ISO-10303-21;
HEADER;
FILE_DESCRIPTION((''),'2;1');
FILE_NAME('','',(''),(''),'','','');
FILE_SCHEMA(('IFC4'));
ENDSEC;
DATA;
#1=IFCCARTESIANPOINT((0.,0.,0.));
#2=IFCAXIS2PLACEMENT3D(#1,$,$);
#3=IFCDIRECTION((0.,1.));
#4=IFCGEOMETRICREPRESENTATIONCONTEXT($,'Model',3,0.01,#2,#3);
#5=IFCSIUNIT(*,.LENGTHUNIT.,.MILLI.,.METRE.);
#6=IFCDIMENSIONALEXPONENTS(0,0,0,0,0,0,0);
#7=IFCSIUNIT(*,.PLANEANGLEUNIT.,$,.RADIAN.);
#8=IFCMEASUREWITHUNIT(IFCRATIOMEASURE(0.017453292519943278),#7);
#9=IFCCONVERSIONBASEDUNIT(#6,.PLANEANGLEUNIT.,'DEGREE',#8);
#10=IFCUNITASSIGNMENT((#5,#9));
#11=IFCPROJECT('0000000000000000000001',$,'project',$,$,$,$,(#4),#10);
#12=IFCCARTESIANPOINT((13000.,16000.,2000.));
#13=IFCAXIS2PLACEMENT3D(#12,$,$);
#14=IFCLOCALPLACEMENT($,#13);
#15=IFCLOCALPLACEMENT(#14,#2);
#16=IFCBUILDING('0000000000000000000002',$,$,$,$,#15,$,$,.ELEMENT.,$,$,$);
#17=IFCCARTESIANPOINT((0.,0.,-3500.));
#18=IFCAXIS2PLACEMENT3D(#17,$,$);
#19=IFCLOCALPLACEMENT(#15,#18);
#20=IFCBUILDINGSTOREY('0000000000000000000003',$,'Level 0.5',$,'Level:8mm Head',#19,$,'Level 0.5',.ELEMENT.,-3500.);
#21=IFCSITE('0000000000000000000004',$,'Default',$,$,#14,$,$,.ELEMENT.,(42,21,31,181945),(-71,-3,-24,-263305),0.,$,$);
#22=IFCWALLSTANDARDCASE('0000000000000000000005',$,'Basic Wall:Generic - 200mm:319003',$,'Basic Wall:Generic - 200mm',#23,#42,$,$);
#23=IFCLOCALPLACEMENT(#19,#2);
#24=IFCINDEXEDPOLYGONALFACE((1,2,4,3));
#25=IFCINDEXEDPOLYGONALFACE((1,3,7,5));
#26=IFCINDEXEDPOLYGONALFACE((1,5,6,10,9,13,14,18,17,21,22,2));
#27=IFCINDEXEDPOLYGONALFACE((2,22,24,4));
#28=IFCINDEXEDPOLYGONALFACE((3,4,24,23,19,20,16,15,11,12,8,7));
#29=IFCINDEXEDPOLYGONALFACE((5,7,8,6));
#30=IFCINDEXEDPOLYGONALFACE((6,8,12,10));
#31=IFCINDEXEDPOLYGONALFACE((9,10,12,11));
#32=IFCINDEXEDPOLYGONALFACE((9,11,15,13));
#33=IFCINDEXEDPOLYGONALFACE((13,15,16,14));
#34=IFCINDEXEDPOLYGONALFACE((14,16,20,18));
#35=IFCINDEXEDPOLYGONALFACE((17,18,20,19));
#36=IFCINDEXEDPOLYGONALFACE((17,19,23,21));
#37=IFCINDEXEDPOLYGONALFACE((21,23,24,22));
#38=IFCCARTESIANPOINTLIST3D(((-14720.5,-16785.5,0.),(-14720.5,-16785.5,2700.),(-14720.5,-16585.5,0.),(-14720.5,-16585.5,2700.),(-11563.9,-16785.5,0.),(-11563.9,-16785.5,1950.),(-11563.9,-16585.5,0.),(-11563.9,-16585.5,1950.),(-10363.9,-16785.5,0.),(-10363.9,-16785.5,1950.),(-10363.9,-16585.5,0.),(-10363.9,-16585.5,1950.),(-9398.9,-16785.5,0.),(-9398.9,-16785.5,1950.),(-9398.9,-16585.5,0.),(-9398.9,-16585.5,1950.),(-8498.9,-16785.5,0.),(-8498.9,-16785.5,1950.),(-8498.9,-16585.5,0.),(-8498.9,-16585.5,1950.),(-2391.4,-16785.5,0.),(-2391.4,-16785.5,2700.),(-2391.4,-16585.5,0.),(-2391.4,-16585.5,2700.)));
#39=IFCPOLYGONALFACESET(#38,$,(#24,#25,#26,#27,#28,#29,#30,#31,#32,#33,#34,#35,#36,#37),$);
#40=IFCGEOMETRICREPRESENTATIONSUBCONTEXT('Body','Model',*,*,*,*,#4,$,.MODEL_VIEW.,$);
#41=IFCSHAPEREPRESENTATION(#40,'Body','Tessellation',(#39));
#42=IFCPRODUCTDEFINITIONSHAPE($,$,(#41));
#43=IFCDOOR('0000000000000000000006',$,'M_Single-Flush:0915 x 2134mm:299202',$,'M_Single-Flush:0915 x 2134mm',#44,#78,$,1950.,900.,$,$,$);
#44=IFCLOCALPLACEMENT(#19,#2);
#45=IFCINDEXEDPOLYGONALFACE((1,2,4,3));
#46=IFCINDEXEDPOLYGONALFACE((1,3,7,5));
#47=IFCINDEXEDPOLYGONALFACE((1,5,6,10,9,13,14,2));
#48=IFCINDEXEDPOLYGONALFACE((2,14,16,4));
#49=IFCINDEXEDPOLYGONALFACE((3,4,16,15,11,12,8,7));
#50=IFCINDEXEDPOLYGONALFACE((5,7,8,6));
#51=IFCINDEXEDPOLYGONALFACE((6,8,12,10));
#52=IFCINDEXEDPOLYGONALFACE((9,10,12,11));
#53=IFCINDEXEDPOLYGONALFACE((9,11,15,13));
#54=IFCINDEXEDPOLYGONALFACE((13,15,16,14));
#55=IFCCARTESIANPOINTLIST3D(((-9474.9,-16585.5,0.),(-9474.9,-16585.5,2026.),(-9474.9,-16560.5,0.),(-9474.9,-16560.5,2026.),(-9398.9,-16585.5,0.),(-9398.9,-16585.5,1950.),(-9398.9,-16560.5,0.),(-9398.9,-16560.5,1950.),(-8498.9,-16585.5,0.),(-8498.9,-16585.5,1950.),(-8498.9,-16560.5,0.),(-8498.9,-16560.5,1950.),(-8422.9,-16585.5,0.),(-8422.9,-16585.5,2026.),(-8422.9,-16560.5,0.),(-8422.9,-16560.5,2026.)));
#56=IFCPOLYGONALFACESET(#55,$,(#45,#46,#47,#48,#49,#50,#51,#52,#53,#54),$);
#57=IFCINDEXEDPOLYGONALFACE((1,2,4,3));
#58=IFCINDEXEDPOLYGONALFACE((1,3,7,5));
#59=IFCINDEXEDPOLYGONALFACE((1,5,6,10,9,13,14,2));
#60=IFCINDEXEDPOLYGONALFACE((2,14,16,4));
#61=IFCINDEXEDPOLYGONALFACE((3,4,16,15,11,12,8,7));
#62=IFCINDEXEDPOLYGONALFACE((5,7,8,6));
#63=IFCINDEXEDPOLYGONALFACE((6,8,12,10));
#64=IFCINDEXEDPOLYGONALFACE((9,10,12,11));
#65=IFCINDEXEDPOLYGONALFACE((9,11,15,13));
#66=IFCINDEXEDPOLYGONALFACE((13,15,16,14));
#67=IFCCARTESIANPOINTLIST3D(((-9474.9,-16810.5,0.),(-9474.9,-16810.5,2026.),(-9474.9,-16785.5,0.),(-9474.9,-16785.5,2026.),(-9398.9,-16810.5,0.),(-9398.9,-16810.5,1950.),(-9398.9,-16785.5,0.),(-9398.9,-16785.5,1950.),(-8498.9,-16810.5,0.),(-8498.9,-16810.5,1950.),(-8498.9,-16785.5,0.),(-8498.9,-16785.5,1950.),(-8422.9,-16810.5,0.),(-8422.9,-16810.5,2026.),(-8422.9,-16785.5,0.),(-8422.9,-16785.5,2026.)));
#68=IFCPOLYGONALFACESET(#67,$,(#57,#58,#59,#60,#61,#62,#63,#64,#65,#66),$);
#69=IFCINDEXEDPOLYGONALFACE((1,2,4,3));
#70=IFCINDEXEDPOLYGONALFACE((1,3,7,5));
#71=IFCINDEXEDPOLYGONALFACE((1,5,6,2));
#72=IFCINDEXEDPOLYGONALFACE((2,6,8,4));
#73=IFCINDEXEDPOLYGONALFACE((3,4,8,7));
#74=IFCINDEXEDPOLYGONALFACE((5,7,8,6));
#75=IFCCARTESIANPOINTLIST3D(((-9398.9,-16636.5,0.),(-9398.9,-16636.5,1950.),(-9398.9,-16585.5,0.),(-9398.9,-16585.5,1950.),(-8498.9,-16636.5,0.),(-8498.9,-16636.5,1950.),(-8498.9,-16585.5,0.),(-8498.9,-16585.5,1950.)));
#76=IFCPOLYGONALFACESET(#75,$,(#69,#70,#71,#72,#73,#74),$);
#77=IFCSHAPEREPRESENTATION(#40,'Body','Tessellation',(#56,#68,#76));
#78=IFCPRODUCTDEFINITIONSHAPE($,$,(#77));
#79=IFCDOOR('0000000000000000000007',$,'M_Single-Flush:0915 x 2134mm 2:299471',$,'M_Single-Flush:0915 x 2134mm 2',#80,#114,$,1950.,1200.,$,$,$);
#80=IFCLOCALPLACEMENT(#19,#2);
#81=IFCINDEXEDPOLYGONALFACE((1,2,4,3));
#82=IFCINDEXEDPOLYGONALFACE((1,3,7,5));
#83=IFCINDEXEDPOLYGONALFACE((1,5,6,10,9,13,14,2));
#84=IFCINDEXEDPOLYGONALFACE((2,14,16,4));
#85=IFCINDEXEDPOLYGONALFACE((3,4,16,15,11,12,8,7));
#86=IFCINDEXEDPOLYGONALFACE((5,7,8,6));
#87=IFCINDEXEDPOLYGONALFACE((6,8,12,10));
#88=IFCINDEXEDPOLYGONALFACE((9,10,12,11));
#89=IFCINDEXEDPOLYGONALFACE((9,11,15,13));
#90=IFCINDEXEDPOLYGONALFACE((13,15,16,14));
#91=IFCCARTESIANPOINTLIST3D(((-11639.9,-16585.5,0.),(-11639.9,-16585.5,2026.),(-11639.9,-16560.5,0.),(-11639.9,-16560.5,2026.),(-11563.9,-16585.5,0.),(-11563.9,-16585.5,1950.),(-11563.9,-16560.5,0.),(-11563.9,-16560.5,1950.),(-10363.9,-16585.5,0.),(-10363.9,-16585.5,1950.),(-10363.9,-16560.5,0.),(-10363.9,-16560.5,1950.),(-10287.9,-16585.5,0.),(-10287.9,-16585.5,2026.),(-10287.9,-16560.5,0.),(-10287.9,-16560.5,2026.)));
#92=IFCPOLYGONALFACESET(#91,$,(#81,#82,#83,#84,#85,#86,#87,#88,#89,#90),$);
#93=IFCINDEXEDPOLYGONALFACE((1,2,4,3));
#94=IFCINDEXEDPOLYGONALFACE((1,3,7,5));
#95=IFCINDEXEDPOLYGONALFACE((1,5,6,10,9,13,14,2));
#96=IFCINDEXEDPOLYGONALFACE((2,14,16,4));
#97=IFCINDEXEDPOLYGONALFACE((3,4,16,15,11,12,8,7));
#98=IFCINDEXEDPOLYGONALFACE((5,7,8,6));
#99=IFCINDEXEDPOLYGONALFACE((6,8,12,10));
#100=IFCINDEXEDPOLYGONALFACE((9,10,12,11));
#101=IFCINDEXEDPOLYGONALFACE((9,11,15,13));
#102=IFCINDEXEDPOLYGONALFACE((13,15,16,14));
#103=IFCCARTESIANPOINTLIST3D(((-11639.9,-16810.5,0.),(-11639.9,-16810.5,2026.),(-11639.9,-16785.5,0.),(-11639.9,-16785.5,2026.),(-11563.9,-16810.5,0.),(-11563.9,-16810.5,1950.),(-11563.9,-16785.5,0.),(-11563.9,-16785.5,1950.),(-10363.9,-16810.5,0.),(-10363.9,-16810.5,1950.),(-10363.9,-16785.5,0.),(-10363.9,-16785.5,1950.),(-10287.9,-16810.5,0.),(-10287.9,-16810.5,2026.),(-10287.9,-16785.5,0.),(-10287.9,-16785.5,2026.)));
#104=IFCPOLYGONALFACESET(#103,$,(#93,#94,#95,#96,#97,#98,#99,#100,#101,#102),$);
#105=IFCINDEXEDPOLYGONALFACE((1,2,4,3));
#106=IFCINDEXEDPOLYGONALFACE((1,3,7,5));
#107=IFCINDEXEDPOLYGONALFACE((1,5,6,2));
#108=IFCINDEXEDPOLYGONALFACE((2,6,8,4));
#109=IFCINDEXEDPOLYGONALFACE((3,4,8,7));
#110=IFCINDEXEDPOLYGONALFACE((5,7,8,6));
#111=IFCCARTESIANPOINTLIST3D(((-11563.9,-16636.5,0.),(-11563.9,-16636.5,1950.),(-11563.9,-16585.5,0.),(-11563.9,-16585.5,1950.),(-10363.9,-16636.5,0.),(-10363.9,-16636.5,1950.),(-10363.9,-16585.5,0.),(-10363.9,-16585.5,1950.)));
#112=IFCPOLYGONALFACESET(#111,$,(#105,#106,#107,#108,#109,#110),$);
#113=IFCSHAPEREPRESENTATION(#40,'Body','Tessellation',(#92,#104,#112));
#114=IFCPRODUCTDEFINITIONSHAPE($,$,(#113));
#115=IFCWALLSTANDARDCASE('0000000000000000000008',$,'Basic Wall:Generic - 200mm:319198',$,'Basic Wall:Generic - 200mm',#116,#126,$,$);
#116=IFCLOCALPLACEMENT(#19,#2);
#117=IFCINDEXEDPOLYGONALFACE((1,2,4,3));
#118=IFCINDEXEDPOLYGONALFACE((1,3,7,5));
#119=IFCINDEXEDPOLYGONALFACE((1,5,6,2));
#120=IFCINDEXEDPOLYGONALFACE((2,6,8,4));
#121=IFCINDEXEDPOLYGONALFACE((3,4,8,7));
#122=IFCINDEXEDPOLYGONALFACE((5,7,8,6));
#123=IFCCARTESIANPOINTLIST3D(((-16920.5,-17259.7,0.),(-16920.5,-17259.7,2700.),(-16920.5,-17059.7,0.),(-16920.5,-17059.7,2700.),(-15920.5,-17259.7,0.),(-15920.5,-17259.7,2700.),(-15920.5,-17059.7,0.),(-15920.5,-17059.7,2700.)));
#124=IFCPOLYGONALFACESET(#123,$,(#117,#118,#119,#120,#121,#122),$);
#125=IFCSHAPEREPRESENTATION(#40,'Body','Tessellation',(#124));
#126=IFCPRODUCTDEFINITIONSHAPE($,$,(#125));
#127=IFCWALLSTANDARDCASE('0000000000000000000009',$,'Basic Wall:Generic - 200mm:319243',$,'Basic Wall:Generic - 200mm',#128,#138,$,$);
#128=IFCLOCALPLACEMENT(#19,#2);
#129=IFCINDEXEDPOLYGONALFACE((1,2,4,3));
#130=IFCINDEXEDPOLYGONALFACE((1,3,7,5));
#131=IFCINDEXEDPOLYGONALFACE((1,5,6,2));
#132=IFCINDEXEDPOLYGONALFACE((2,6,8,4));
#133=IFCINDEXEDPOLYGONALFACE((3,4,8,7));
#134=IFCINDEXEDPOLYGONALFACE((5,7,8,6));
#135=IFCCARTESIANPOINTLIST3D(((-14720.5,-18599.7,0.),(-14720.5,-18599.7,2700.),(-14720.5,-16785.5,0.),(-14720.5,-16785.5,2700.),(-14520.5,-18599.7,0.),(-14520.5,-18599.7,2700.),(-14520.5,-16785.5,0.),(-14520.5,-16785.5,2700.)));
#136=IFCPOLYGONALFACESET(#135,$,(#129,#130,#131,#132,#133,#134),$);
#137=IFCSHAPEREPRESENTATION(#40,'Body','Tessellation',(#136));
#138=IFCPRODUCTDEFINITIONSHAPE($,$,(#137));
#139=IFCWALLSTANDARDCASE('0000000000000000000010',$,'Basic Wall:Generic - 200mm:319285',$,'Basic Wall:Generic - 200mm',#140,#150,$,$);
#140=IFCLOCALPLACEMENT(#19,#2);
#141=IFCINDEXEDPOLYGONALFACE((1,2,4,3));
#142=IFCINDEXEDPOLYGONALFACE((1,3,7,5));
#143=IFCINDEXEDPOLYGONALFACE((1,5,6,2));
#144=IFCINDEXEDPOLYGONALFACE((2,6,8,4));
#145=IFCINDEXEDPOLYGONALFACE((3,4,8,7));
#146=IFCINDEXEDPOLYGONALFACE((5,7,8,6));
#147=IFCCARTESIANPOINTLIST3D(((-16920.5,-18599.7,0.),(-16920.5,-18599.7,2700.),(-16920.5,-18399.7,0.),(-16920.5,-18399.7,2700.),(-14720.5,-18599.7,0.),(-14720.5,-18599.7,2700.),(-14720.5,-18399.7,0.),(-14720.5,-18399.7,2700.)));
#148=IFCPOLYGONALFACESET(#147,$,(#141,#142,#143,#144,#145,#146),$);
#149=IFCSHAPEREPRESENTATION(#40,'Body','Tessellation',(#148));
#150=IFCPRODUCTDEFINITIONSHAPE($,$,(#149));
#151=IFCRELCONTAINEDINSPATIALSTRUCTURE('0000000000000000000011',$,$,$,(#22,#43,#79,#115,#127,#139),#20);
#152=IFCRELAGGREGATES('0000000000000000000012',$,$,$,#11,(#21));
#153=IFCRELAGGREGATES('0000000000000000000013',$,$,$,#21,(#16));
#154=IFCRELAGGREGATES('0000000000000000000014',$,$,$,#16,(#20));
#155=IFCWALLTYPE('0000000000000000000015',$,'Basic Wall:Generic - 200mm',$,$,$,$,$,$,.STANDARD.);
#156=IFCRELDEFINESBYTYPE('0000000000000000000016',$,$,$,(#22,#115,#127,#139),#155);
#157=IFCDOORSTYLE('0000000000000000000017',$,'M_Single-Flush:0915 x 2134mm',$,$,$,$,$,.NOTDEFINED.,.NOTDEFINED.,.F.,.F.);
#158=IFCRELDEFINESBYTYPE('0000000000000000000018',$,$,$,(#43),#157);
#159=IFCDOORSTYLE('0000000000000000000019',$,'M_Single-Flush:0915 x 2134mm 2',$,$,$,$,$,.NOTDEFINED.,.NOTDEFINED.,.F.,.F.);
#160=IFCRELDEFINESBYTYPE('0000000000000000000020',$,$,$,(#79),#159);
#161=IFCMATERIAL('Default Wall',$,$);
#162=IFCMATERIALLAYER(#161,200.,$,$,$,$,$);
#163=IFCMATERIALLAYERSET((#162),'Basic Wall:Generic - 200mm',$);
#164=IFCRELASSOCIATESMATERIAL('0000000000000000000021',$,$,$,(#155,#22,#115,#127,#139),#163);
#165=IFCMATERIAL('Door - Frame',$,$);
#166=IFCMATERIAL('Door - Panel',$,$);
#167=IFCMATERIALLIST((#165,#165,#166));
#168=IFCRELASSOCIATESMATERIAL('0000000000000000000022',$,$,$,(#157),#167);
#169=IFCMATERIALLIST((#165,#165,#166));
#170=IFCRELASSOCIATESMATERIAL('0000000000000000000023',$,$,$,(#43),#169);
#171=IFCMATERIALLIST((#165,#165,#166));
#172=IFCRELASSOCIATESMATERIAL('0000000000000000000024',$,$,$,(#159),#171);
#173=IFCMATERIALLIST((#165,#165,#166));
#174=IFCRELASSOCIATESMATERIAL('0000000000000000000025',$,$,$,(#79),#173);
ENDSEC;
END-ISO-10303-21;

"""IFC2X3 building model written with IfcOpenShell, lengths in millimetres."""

from ifc_helpers import new_model, entity, si_unit, converted_unit, direction, frame, frame_2d, origin, place, context, subcontext, project, spatial, polyline, rectangle, outline, extrude, source, transform, mapped, material, material_list, layer, layer_set, layer_usage, type_object, type_shapes, element, fill, save


model = new_model("IFC2X3")

# Units and contexts
model_context = context("Model", 3, precision=0.01, world=origin(), true_north=direction((0.0, 1.0)))
body_context = subcontext(model_context, "Body", "Model", "MODEL_VIEW")
ifc_project = project(units=[si_unit("LENGTHUNIT", "METRE", prefix="MILLI"), converted_unit("PLANEANGLEUNIT", "DEGREE", entity("IfcRatioMeasure", 0.017453292519943278), si_unit("PLANEANGLEUNIT", "RADIAN"), dimensions=[0, 0, 0, 0, 0, 0, 0])], contexts=[model_context])

# Site, building, storey
site_placement = place(None, frame((13000.0, 16000.0, 2000.0)))
site = spatial("IfcSite", under=ifc_project, at=site_placement, Name="Default", CompositionType="ELEMENT", RefLatitude=(42, 21, 31, 181945), RefLongitude=(-71, -3, -24, -263305), RefElevation=0.0)
building_placement = place(site_placement, origin())
building = spatial("IfcBuilding", under=site, at=building_placement, CompositionType="ELEMENT")
storey_placement = place(building_placement, frame((0.0, 0.0, -3500.0)))
storey = spatial("IfcBuildingStorey", under=building, at=storey_placement, Name="Level 0.5", ObjectType="Level:8mm Head", LongName="Level 0.5", CompositionType="ELEMENT", Elevation=-3500.0)

# Shared definitions
ifc_material_1 = material(Name="Default Wall")
ifc_layer_1 = layer(ifc_material_1, 200.0)
ifc_layer_set_1 = layer_set([ifc_layer_1], Name="Basic Wall:Generic - 200mm")
wall_type_1 = type_object("IfcWallType", Name="Basic Wall:Generic - 200mm", PredefinedType="STANDARD", material=ifc_layer_set_1)

# Shared definitions
ifc_material_2 = material(Name="Door - Frame")
ifc_material_3 = material(Name="Door - Panel")
ifc_material_list_1 = material_list([ifc_material_2, ifc_material_2, ifc_material_3])
door_style_1 = type_object("IfcDoorStyle", Name="M_Single-Flush:0915 x 2134mm", ConstructionType="NOTDEFINED", OperationType="NOTDEFINED", ParameterTakesPrecedence=False, Sizeable=False, material=ifc_material_list_1)
shared_shape_1 = source(origin(), body_context, "Body", "SweptSolid", [
    extrude(outline(polyline([(-526.0, -1032.0), (526.0, -1032.0), (526.0, 994.0), (450.0, 994.0), (450.0, -956.0), (-450.0, -956.0), (-450.0, 994.0), (-526.0, 994.0), (-526.0, -1032.0)])), frame((450.0, 225.0, 994.0), z_axis=(0.0, -1.0, 0.0), x_axis=(-1.0, 0.0, 0.0)), (0.0, 0.0, 1.0), 25.0),
    extrude(outline(polyline([(-1032.0, -526.0), (994.0, -526.0), (994.0, -450.0), (-956.0, -450.0), (-956.0, 450.0), (994.0, 450.0), (994.0, 526.0), (-1032.0, 526.0), (-1032.0, -526.0)])), frame((450.0, 0.0, 994.0), z_axis=(0.0, -1.0, 0.0), x_axis=(0.0, 0.0, -1.0)), (0.0, 0.0, 1.0), 25.0),
    extrude(rectangle(XDim=900.0, YDim=51.0, at=frame_2d((0.0, 0.0), x_axis=(1.0, 0.0))), frame((450.0, 174.5, 0.0)), (0.0, 0.0, 1.0), 1950.0),
])
type_shapes(door_style_1, [shared_shape_1])

# Wall, openings, doors
ifc_layer_usage_1 = layer_usage(ifc_layer_set_1, "AXIS2", "NEGATIVE", 100.0)
wall_1_placement = place(storey_placement, frame((-14720.5, -16685.5, 0.0)))
wall_1 = element("IfcWallStandardCase", 1, at=wall_1_placement, inside=storey, type_object=wall_type_1, material=ifc_layer_usage_1, Name="Basic Wall:Generic - 200mm:319003", ObjectType="Basic Wall:Generic - 200mm", context=body_context, shape_type="SweptSolid", body=[
    extrude(rectangle(XDim=12329.1, YDim=200.0, at=frame_2d((6164.6, 0.0), x_axis=(1.0, 0.0))), origin(), (0.0, 0.0, 1.0), 2700.0),
])
opening_1_placement = place(wall_1_placement, frame((5321.6, -100.0, 0.0)))
opening_1 = element("IfcOpeningElement", 2, at=opening_1_placement, cuts=wall_1, ObjectType="Opening", context=body_context, shape_type="SweptSolid", body=[
    extrude(rectangle(XDim=900.0, YDim=1950.0, at=frame_2d((975.0, 450.0), x_axis=(0.0, -1.0))), frame((0.0, 0.0, 0.0), z_axis=(0.0, 1.0, 0.0), x_axis=(0.0, 0.0, 1.0)), (0.0, 0.0, 1.0), 200.0),
])
opening_2_placement = place(wall_1_placement, frame((3156.6, -100.0, 0.0)))
opening_2 = element("IfcOpeningElement", 3, at=opening_2_placement, cuts=wall_1, ObjectType="Opening", context=body_context, shape_type="SweptSolid", body=[
    extrude(rectangle(XDim=1200.0, YDim=1950.0, at=frame_2d((975.0, 600.0), x_axis=(0.0, -1.0))), frame((0.0, 0.0, 0.0), z_axis=(0.0, 1.0, 0.0), x_axis=(0.0, 0.0, 1.0)), (0.0, 0.0, 1.0), 200.0),
])
ifc_material_list_2 = material_list([ifc_material_2, ifc_material_2, ifc_material_3])
door_1_placement = place(opening_1_placement, origin())
door_1 = element("IfcDoor", 4, at=door_1_placement, inside=storey, type_object=door_style_1, material=ifc_material_list_2, Name="M_Single-Flush:0915 x 2134mm:299202", ObjectType="M_Single-Flush:0915 x 2134mm", OverallHeight=1950.0, OverallWidth=900.0, context=body_context, shape_type="MappedRepresentation", body=[
    mapped(shared_shape_1, transform((0.0, 0.0, 0.0), scale=1.0)),
])
fill(opening_1, door_1)
ifc_material_list_3 = material_list([ifc_material_2, ifc_material_2, ifc_material_3])
ifc_material_list_4 = material_list([ifc_material_2, ifc_material_2, ifc_material_3])
door_style_2 = type_object("IfcDoorStyle", Name="M_Single-Flush:0915 x 2134mm 2", ConstructionType="NOTDEFINED", OperationType="NOTDEFINED", ParameterTakesPrecedence=False, Sizeable=False, material=ifc_material_list_4)
shared_shape_2 = source(origin(), body_context, "Body", "SweptSolid", [
    extrude(outline(polyline([(-676.0, -1032.0), (676.0, -1032.0), (676.0, 994.0), (600.0, 994.0), (600.0, -956.0), (-600.0, -956.0), (-600.0, 994.0), (-676.0, 994.0), (-676.0, -1032.0)])), frame((600.0, 225.0, 994.0), z_axis=(0.0, -1.0, 0.0), x_axis=(-1.0, 0.0, 0.0)), (0.0, 0.0, 1.0), 25.0),
    extrude(outline(polyline([(-1032.0, -676.0), (994.0, -676.0), (994.0, -600.0), (-956.0, -600.0), (-956.0, 600.0), (994.0, 600.0), (994.0, 676.0), (-1032.0, 676.0), (-1032.0, -676.0)])), frame((600.0, 0.0, 994.0), z_axis=(0.0, -1.0, 0.0), x_axis=(0.0, 0.0, -1.0)), (0.0, 0.0, 1.0), 25.0),
    extrude(rectangle(XDim=1200.0, YDim=51.0, at=frame_2d((0.0, 0.0), x_axis=(1.0, 0.0))), frame((600.0, 174.5, 0.0)), (0.0, 0.0, 1.0), 1950.0),
])
type_shapes(door_style_2, [shared_shape_2])
door_2_placement = place(opening_2_placement, origin())
door_2 = element("IfcDoor", 5, at=door_2_placement, inside=storey, type_object=door_style_2, material=ifc_material_list_3, Name="M_Single-Flush:0915 x 2134mm 2:299471", ObjectType="M_Single-Flush:0915 x 2134mm 2", OverallHeight=1950.0, OverallWidth=1200.0, context=body_context, shape_type="MappedRepresentation", body=[
    mapped(shared_shape_2, transform((0.0, 0.0, 0.0), scale=1.0)),
])
fill(opening_2, door_2)

# Walls
ifc_layer_usage_2 = layer_usage(ifc_layer_set_1, "AXIS2", "NEGATIVE", 100.0)
wall_2_placement = place(storey_placement, frame((-15920.5, -17159.7, 0.0), z_axis=(0.0, 0.0, 1.0), x_axis=(-1.0, 0.0, 0.0)))
element("IfcWallStandardCase", 6, at=wall_2_placement, inside=storey, type_object=wall_type_1, material=ifc_layer_usage_2, Name="Basic Wall:Generic - 200mm:319198", ObjectType="Basic Wall:Generic - 200mm", context=body_context, shape_type="SweptSolid", body=[
    extrude(rectangle(XDim=1000.0, YDim=200.0, at=frame_2d((500.0, 0.0), x_axis=(-1.0, 0.0))), origin(), (0.0, 0.0, 1.0), 2700.0),
])
ifc_layer_usage_3 = layer_usage(ifc_layer_set_1, "AXIS2", "NEGATIVE", 100.0)
wall_3_placement = place(storey_placement, frame((-14620.5, -16785.5, 0.0), z_axis=(0.0, 0.0, 1.0), x_axis=(0.0, -1.0, 0.0)))
element("IfcWallStandardCase", 7, at=wall_3_placement, inside=storey, type_object=wall_type_1, material=ifc_layer_usage_3, Name="Basic Wall:Generic - 200mm:319243", ObjectType="Basic Wall:Generic - 200mm", context=body_context, shape_type="SweptSolid", body=[
    extrude(rectangle(XDim=1814.2, YDim=200.0, at=frame_2d((907.1, 0.0), x_axis=(-1.0, 0.0))), origin(), (0.0, 0.0, 1.0), 2700.0),
])
ifc_layer_usage_4 = layer_usage(ifc_layer_set_1, "AXIS2", "NEGATIVE", 100.0)
wall_4_placement = place(storey_placement, frame((-14720.5, -18499.7, 0.0), z_axis=(0.0, 0.0, 1.0), x_axis=(-1.0, 0.0, 0.0)))
element("IfcWallStandardCase", 8, at=wall_4_placement, inside=storey, type_object=wall_type_1, material=ifc_layer_usage_4, Name="Basic Wall:Generic - 200mm:319285", ObjectType="Basic Wall:Generic - 200mm", context=body_context, shape_type="SweptSolid", body=[
    extrude(rectangle(XDim=2200.0, YDim=200.0, at=frame_2d((1100.0, 0.0), x_axis=(-1.0, 0.0))), origin(), (0.0, 0.0, 1.0), 2700.0),
])

save(model, "model.ifc")
